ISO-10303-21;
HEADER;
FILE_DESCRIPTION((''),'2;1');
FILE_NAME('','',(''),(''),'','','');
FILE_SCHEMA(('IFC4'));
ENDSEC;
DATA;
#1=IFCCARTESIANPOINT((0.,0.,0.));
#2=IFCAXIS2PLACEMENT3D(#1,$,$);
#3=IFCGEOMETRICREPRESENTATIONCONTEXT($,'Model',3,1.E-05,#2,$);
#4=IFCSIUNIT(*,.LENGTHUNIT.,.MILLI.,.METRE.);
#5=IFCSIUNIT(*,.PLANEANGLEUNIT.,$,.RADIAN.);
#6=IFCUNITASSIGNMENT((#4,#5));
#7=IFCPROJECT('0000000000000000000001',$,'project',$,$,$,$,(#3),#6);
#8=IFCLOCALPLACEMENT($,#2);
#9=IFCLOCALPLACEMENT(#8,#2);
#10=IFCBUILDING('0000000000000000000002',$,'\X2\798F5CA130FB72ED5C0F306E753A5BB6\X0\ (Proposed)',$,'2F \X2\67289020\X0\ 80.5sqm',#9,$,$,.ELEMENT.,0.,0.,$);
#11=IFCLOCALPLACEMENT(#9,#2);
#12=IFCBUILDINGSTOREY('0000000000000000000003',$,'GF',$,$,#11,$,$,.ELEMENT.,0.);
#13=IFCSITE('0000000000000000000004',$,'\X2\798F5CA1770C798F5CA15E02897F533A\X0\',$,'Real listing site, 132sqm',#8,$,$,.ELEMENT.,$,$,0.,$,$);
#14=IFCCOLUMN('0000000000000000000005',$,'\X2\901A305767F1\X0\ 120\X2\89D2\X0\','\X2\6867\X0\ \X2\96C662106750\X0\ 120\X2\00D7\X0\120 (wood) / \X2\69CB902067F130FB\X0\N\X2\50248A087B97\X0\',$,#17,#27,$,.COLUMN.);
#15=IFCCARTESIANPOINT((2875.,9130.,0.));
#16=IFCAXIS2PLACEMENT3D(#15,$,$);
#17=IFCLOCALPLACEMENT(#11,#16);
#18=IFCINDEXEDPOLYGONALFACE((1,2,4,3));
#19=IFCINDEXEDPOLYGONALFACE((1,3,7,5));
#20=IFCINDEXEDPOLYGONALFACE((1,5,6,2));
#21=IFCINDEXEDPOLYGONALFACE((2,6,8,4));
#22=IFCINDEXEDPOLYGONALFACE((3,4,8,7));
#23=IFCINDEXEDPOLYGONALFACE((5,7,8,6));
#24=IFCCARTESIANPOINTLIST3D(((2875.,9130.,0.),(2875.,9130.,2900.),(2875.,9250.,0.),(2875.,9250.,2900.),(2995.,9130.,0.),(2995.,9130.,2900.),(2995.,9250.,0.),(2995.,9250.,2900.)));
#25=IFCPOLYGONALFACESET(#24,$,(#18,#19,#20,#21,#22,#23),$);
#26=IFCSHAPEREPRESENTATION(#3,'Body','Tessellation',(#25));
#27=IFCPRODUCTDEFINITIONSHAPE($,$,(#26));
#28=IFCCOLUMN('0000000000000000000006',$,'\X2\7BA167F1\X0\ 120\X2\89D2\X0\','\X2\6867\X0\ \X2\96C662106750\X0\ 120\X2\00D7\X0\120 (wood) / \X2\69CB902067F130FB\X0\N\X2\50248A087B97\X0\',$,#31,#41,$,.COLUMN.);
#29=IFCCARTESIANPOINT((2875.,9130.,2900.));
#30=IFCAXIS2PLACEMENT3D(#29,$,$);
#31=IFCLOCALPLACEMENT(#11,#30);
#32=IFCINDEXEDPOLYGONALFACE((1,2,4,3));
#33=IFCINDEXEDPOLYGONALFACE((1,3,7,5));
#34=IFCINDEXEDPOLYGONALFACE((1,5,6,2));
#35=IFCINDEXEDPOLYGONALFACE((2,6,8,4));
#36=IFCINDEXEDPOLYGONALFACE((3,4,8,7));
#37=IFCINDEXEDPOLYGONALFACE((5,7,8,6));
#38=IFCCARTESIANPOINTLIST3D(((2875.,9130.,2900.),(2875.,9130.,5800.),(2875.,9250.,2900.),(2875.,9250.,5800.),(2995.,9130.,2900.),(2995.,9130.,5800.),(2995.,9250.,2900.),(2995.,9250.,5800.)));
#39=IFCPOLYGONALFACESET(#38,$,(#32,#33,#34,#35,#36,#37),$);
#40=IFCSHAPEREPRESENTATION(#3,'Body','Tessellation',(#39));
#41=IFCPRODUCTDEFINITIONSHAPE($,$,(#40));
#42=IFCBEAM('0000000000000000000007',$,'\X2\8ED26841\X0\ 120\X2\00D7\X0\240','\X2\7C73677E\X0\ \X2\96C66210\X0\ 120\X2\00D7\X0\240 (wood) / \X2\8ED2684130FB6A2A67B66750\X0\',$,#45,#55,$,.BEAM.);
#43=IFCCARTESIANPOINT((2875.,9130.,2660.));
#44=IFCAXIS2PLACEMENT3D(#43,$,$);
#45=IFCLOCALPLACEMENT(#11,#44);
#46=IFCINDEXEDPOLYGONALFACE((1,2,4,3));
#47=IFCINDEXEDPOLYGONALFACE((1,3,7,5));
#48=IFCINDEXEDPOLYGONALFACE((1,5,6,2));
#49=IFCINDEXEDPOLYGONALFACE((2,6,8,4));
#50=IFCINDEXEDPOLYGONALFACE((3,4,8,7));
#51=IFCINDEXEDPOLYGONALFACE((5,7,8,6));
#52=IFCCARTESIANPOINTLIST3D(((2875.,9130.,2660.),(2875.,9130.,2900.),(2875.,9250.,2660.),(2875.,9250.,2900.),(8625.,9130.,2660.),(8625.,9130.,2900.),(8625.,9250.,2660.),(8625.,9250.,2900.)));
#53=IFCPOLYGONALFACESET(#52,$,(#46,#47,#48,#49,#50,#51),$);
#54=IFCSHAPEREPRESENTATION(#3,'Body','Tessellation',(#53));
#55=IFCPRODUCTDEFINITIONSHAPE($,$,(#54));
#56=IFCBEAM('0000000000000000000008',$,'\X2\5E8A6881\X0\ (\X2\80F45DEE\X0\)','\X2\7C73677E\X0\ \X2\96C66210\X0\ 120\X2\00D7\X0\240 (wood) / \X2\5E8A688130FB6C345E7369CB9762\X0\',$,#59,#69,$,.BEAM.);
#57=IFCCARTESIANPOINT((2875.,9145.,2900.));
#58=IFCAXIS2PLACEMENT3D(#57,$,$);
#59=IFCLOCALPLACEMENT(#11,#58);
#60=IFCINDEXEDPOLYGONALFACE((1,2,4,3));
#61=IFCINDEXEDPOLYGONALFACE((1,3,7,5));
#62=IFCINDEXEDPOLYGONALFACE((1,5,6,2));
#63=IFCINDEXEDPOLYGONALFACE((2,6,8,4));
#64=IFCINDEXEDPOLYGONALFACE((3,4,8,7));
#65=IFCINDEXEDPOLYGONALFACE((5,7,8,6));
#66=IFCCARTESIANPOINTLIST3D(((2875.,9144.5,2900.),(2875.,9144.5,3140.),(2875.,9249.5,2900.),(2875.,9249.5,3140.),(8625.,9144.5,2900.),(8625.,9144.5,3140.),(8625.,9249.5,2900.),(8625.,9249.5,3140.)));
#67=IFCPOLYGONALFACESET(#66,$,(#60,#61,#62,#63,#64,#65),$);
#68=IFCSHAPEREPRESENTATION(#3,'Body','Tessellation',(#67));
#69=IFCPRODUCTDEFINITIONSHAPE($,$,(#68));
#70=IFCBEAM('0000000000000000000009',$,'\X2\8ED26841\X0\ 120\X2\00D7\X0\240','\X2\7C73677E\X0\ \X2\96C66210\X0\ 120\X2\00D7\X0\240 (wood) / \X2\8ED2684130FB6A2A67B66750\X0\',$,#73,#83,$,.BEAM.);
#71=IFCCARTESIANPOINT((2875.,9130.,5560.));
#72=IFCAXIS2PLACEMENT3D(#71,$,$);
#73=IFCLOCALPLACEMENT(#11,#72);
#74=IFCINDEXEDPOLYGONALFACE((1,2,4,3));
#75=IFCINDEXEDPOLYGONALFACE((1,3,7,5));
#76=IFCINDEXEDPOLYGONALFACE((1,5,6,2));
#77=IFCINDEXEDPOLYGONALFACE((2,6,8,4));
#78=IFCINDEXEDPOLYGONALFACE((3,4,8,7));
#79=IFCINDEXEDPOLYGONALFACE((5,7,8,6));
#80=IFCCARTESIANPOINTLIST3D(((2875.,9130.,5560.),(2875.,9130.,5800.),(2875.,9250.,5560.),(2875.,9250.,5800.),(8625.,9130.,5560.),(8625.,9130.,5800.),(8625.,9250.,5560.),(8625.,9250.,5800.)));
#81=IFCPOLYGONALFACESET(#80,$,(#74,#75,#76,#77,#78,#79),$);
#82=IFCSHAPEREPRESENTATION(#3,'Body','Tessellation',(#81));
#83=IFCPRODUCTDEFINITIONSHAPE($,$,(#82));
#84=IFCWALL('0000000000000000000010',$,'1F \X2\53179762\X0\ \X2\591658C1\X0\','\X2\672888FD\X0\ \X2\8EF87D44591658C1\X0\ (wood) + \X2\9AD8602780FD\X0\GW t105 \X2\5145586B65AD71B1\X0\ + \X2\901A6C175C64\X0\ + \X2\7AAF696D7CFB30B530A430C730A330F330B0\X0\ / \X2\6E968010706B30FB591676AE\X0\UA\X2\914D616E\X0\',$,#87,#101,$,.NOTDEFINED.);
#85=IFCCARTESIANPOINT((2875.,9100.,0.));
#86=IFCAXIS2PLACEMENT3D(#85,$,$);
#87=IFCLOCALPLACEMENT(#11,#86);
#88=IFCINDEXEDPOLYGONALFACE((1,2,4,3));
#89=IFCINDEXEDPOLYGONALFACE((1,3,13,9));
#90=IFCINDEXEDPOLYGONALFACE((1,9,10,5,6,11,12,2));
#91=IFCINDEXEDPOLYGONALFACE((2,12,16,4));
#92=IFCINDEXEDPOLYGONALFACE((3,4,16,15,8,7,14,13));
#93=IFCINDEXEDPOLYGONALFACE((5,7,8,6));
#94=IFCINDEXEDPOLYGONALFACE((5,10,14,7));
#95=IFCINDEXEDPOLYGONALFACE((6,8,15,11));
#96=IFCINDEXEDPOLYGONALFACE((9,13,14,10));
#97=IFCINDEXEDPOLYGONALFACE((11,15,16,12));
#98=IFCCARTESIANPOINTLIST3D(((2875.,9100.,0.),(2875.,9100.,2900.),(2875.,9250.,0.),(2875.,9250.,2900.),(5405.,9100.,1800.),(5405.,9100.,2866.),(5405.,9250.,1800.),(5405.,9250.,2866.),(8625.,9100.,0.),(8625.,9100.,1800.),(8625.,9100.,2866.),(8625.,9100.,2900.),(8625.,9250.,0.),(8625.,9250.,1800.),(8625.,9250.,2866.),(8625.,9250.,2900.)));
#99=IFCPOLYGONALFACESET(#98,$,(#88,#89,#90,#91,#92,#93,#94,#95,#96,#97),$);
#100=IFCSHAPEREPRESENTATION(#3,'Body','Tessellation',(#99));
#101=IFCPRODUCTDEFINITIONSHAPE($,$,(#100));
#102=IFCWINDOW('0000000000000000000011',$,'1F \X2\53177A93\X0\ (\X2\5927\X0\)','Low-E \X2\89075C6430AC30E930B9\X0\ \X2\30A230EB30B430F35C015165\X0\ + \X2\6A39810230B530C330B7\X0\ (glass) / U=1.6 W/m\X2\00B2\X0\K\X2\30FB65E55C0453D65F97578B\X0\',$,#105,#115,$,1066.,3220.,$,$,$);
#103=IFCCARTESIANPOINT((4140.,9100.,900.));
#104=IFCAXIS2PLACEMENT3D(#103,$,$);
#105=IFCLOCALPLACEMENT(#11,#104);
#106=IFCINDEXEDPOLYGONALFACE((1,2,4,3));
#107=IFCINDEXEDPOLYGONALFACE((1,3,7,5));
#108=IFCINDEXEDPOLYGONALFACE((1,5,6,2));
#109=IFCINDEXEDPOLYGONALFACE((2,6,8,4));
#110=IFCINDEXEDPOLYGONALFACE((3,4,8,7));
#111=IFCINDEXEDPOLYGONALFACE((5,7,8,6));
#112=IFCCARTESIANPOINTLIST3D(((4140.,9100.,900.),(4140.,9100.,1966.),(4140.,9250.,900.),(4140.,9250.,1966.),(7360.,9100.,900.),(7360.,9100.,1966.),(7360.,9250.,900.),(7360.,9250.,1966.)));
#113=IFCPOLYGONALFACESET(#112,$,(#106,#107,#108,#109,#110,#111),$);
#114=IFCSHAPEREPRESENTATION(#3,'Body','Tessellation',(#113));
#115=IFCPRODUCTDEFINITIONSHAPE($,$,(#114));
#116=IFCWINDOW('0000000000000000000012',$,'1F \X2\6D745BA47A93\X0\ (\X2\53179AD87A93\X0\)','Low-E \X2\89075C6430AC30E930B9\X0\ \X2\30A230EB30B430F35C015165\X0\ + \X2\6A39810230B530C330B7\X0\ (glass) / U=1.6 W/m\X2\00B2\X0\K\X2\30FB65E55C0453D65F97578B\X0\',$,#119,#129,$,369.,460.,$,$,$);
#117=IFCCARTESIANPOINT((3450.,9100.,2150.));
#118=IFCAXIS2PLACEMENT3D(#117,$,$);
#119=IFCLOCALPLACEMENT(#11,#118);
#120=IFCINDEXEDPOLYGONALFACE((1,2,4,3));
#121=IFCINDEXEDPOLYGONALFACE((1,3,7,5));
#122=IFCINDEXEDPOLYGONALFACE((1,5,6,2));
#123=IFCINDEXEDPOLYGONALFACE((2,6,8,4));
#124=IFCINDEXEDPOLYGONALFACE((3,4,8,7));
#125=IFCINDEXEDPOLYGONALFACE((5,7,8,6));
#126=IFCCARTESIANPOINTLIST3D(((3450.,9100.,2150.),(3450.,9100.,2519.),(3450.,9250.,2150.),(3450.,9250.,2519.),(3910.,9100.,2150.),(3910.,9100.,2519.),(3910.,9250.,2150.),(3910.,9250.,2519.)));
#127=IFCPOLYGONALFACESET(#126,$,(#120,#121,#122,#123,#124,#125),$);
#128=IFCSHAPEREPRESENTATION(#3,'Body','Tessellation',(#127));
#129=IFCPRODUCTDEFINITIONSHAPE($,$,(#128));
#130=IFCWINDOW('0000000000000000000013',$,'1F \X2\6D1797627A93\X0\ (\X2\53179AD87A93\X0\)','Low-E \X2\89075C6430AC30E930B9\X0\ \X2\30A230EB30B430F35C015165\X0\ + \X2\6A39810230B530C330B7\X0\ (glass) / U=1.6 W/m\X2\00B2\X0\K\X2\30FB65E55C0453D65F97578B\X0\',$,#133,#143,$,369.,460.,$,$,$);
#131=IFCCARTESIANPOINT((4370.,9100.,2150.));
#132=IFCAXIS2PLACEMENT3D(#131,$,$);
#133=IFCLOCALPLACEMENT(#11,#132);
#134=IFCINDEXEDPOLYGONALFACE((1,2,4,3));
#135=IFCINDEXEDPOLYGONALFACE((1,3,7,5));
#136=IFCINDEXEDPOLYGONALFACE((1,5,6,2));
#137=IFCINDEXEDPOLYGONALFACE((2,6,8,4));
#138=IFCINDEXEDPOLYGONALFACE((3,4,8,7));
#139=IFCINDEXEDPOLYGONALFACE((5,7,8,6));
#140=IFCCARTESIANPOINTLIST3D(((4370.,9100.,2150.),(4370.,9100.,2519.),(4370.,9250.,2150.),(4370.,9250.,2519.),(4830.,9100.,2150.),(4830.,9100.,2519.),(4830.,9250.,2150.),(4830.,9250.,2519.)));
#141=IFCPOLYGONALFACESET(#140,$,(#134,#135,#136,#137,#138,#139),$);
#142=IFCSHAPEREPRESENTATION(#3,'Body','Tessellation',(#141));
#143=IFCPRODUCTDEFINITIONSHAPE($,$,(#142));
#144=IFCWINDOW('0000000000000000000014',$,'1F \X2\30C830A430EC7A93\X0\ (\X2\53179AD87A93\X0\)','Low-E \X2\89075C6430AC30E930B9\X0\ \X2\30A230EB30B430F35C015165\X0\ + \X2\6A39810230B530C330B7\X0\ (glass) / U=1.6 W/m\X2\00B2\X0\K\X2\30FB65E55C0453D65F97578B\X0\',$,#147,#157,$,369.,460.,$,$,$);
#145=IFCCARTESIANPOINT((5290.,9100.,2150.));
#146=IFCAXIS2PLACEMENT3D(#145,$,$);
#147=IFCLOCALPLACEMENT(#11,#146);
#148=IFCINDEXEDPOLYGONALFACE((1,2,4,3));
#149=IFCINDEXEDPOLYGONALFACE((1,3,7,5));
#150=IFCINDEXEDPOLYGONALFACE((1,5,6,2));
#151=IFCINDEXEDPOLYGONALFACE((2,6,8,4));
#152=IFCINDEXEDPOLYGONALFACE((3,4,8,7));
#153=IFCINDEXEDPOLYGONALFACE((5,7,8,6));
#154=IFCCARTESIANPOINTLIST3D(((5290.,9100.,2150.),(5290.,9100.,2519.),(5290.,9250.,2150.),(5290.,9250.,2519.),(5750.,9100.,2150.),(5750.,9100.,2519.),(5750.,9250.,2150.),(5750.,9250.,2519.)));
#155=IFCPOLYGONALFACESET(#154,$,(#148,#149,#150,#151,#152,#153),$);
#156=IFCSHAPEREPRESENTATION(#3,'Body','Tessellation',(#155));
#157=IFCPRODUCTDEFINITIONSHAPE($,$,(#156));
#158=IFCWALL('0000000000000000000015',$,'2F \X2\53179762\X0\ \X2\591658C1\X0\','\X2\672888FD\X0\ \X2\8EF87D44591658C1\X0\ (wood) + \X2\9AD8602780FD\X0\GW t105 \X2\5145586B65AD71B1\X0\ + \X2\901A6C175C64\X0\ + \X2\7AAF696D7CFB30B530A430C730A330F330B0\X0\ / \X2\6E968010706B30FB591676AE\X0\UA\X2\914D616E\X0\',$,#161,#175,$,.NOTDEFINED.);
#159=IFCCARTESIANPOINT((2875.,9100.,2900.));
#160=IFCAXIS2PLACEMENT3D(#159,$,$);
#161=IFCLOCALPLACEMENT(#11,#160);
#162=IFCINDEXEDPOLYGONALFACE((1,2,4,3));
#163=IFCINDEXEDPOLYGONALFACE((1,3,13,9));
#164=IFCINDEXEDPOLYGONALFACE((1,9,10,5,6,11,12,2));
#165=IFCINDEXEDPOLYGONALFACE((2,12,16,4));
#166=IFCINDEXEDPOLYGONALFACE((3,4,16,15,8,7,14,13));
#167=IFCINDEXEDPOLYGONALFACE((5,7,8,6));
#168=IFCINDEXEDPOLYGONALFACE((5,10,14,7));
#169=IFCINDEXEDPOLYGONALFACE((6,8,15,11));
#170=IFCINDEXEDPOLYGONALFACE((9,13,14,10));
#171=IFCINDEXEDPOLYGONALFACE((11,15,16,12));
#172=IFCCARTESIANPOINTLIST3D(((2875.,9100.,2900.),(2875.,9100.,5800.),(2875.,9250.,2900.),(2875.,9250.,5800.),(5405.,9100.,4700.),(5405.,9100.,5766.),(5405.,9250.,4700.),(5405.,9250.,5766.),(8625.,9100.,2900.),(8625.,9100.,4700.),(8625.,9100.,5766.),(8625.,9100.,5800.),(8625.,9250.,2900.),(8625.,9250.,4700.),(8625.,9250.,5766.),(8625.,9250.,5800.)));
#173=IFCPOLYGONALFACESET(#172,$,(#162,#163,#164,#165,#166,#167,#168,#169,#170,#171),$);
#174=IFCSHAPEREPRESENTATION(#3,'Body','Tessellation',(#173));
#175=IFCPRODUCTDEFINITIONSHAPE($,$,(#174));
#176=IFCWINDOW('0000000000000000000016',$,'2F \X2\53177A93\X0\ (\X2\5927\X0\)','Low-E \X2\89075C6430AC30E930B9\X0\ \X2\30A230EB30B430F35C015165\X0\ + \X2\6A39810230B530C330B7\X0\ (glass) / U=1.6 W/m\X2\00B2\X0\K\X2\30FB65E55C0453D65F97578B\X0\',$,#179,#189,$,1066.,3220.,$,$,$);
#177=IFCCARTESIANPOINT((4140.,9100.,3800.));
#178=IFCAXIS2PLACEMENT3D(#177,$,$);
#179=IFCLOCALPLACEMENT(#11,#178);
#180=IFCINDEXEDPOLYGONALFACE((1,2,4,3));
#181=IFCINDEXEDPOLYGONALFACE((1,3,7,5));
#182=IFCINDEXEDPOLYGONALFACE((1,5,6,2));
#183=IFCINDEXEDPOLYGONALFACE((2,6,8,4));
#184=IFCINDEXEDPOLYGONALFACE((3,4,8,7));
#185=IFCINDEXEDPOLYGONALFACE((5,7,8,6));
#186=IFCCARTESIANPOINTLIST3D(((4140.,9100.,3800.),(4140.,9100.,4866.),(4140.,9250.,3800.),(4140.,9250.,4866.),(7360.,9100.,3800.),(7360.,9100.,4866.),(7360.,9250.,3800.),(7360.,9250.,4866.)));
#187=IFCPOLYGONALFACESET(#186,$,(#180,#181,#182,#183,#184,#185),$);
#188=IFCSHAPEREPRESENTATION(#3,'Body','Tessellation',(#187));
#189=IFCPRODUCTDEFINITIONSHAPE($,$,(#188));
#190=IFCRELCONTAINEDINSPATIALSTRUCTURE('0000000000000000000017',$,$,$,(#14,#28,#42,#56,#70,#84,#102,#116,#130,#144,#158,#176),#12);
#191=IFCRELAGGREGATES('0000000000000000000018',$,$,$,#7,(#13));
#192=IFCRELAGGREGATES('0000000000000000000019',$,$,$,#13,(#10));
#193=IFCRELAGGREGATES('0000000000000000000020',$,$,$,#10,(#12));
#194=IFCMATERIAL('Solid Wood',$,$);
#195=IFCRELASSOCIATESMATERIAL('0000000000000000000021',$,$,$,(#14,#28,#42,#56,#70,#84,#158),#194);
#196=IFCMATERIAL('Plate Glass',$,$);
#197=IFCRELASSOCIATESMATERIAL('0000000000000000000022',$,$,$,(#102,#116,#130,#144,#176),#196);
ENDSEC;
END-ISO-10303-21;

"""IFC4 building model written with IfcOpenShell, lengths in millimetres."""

from ifc_helpers import new_model, si_unit, frame, frame_2d, origin, place, context, project, spatial, rectangle, extrude, material, element, fill, save


model = new_model("IFC4")

# Units and contexts
model_context = context("Model", 3, precision=1e-05, world=origin())
ifc_project = project(units=[si_unit("LENGTHUNIT", "METRE", prefix="MILLI"), si_unit("PLANEANGLEUNIT", "RADIAN")], contexts=[model_context])

# Site, building, storey
site_placement = place(None, origin())
site = spatial("IfcSite", under=ifc_project, at=site_placement, Name="福岡県福岡市西区", ObjectType="Real listing site, 132sqm", CompositionType="ELEMENT", RefElevation=0.0)
building_placement = place(site_placement, origin())
building = spatial("IfcBuilding", under=site, at=building_placement, Name="福岡・狭小の町家 (Proposed)", ObjectType="2F 木造 80.5sqm", CompositionType="ELEMENT", ElevationOfRefHeight=0.0, ElevationOfTerrain=0.0)
storey_placement = place(building_placement, origin())
storey = spatial("IfcBuildingStorey", under=building, at=storey_placement, Name="GF", CompositionType="ELEMENT", Elevation=0.0)

# Columns
ifc_material_1 = material(Name="Solid Wood")
column_1_placement = place(storey_placement, frame((2875.0, 9130.0, 0.0)))
element("IfcColumn", 1, at=column_1_placement, inside=storey, material=ifc_material_1, Name="通し柱 120角", Description="桧 集成材 120×120 (wood) / 構造柱・N値計算", PredefinedType="COLUMN", context=model_context, shape_type="SweptSolid", body=[
    extrude(rectangle(XDim=120.0, YDim=120.0, at=frame_2d((60.0, 60.0))), frame((2875.0, 9130.0, 0.0)), (0.0, 0.0, 1.0), 2900.0),
])
column_2_placement = place(storey_placement, frame((2875.0, 9130.0, 2900.0)))
element("IfcColumn", 2, at=column_2_placement, inside=storey, material=ifc_material_1, Name="管柱 120角", Description="桧 集成材 120×120 (wood) / 構造柱・N値計算", PredefinedType="COLUMN", context=model_context, shape_type="SweptSolid", body=[
    extrude(rectangle(XDim=120.0, YDim=120.0, at=frame_2d((60.0, 60.0))), frame((2875.0, 9130.0, 2900.0)), (0.0, 0.0, 1.0), 2900.0),
])

# Beams
beam_1_placement = place(storey_placement, frame((2875.0, 9130.0, 2660.0)))
element("IfcBeam", 3, at=beam_1_placement, inside=storey, material=ifc_material_1, Name="軒桁 120×240", Description="米松 集成 120×240 (wood) / 軒桁・横架材", PredefinedType="BEAM", context=model_context, shape_type="SweptSolid", body=[
    extrude(rectangle(XDim=5750.0, YDim=120.0, at=frame_2d((2875.0, 60.0))), frame((2875.0, 9130.0, 2660.0)), (0.0, 0.0, 1.0), 240.0),
])
beam_2_placement = place(storey_placement, frame((2875.0, 9145.0, 2900.0)))
element("IfcBeam", 4, at=beam_2_placement, inside=storey, material=ifc_material_1, Name="床梁 (胴差)", Description="米松 集成 120×240 (wood) / 床梁・水平構面", PredefinedType="BEAM", context=model_context, shape_type="SweptSolid", body=[
    extrude(rectangle(XDim=5750.0, YDim=105.0, at=frame_2d((2875.0, 52.0))), frame((2875.0, 9145.0, 2900.0)), (0.0, 0.0, 1.0), 240.0),
])
beam_3_placement = place(storey_placement, frame((2875.0, 9130.0, 5560.0)))
element("IfcBeam", 5, at=beam_3_placement, inside=storey, material=ifc_material_1, Name="軒桁 120×240", Description="米松 集成 120×240 (wood) / 軒桁・横架材", PredefinedType="BEAM", context=model_context, shape_type="SweptSolid", body=[
    extrude(rectangle(XDim=5750.0, YDim=120.0, at=frame_2d((2875.0, 60.0))), frame((2875.0, 9130.0, 5560.0)), (0.0, 0.0, 1.0), 240.0),
])

# Wall, openings, windows
wall_1_placement = place(storey_placement, frame((2875.0, 9100.0, 0.0)))
wall_1 = element("IfcWall", 6, at=wall_1_placement, inside=storey, material=ifc_material_1, Name="1F 北面 外壁", Description="木製 軸組外壁 (wood) + 高性能GW t105 充填断熱 + 通気層 + 窯業系サイディング / 準耐火・外皮UA配慮", PredefinedType="NOTDEFINED", context=model_context, shape_type="SweptSolid", body=[
    extrude(rectangle(XDim=5750.0, YDim=150.0, at=frame_2d((2875.0, 75.0))), frame((2875.0, 9100.0, 0.0)), (0.0, 0.0, 1.0), 2900.0),
])
opening_1_placement = place(storey_placement, frame((4140.0, 9100.0, 900.0)))
opening_1 = element("IfcOpeningElement", 7, at=opening_1_placement, cuts=wall_1, PredefinedType="NOTDEFINED", context=model_context, shape_type="SweptSolid", body=[
    extrude(rectangle(XDim=3220.0, YDim=150.0, at=frame_2d((1610.0, 75.0))), frame((4140.0, 9100.0, 900.0)), (0.0, 0.0, 1.0), 1066.0),
])
opening_2_placement = place(storey_placement, frame((3450.0, 9100.0, 2150.0)))
opening_2 = element("IfcOpeningElement", 8, at=opening_2_placement, cuts=wall_1, PredefinedType="NOTDEFINED", context=model_context, shape_type="SweptSolid", body=[
    extrude(rectangle(XDim=460.0, YDim=150.0, at=frame_2d((230.0, 75.0))), frame((3450.0, 9100.0, 2150.0)), (0.0, 0.0, 1.0), 369.0),
])
opening_3_placement = place(storey_placement, frame((4370.0, 9100.0, 2150.0)))
opening_3 = element("IfcOpeningElement", 9, at=opening_3_placement, cuts=wall_1, PredefinedType="NOTDEFINED", context=model_context, shape_type="SweptSolid", body=[
    extrude(rectangle(XDim=460.0, YDim=150.0, at=frame_2d((230.0, 75.0))), frame((4370.0, 9100.0, 2150.0)), (0.0, 0.0, 1.0), 369.0),
])
opening_4_placement = place(storey_placement, frame((5290.0, 9100.0, 2150.0)))
opening_4 = element("IfcOpeningElement", 10, at=opening_4_placement, cuts=wall_1, PredefinedType="NOTDEFINED", context=model_context, shape_type="SweptSolid", body=[
    extrude(rectangle(XDim=460.0, YDim=150.0, at=frame_2d((230.0, 75.0))), frame((5290.0, 9100.0, 2150.0)), (0.0, 0.0, 1.0), 369.0),
])
ifc_material_2 = material(Name="Plate Glass")
window_1_placement = place(storey_placement, frame((4140.0, 9100.0, 900.0)))
window_1 = element("IfcWindow", 11, at=window_1_placement, inside=storey, material=ifc_material_2, Name="1F 北窓 (大)", Description="Low-E 複層ガラス アルゴン封入 + 樹脂サッシ (glass) / U=1.6 W/m²K・日射取得型", OverallHeight=1066.0, OverallWidth=3220.0, context=model_context, shape_type="SweptSolid", body=[
    extrude(rectangle(XDim=3220.0, YDim=150.0, at=frame_2d((1610.0, 75.0))), frame((4140.0, 9100.0, 900.0)), (0.0, 0.0, 1.0), 1066.0),
])
fill(opening_1, window_1)
window_2_placement = place(storey_placement, frame((3450.0, 9100.0, 2150.0)))
window_2 = element("IfcWindow", 12, at=window_2_placement, inside=storey, material=ifc_material_2, Name="1F 浴室窓 (北高窓)", Description="Low-E 複層ガラス アルゴン封入 + 樹脂サッシ (glass) / U=1.6 W/m²K・日射取得型", OverallHeight=369.0, OverallWidth=460.0, context=model_context, shape_type="SweptSolid", body=[
    extrude(rectangle(XDim=460.0, YDim=150.0, at=frame_2d((230.0, 75.0))), frame((3450.0, 9100.0, 2150.0)), (0.0, 0.0, 1.0), 369.0),
])
fill(opening_2, window_2)
window_3_placement = place(storey_placement, frame((4370.0, 9100.0, 2150.0)))
window_3 = element("IfcWindow", 13, at=window_3_placement, inside=storey, material=ifc_material_2, Name="1F 洗面窓 (北高窓)", Description="Low-E 複層ガラス アルゴン封入 + 樹脂サッシ (glass) / U=1.6 W/m²K・日射取得型", OverallHeight=369.0, OverallWidth=460.0, context=model_context, shape_type="SweptSolid", body=[
    extrude(rectangle(XDim=460.0, YDim=150.0, at=frame_2d((230.0, 75.0))), frame((4370.0, 9100.0, 2150.0)), (0.0, 0.0, 1.0), 369.0),
])
fill(opening_3, window_3)
window_4_placement = place(storey_placement, frame((5290.0, 9100.0, 2150.0)))
window_4 = element("IfcWindow", 14, at=window_4_placement, inside=storey, material=ifc_material_2, Name="1F トイレ窓 (北高窓)", Description="Low-E 複層ガラス アルゴン封入 + 樹脂サッシ (glass) / U=1.6 W/m²K・日射取得型", OverallHeight=369.0, OverallWidth=460.0, context=model_context, shape_type="SweptSolid", body=[
    extrude(rectangle(XDim=460.0, YDim=150.0, at=frame_2d((230.0, 75.0))), frame((5290.0, 9100.0, 2150.0)), (0.0, 0.0, 1.0), 369.0),
])
fill(opening_4, window_4)

# Wall, opening, window
wall_2_placement = place(storey_placement, frame((2875.0, 9100.0, 2900.0)))
wall_2 = element("IfcWall", 15, at=wall_2_placement, inside=storey, material=ifc_material_1, Name="2F 北面 外壁", Description="木製 軸組外壁 (wood) + 高性能GW t105 充填断熱 + 通気層 + 窯業系サイディング / 準耐火・外皮UA配慮", PredefinedType="NOTDEFINED", context=model_context, shape_type="SweptSolid", body=[
    extrude(rectangle(XDim=5750.0, YDim=150.0, at=frame_2d((2875.0, 75.0))), frame((2875.0, 9100.0, 2900.0)), (0.0, 0.0, 1.0), 2900.0),
])
opening_5_placement = place(storey_placement, frame((4140.0, 9100.0, 3800.0)))
opening_5 = element("IfcOpeningElement", 16, at=opening_5_placement, cuts=wall_2, PredefinedType="NOTDEFINED", context=model_context, shape_type="SweptSolid", body=[
    extrude(rectangle(XDim=3220.0, YDim=150.0, at=frame_2d((1610.0, 75.0))), frame((4140.0, 9100.0, 3800.0)), (0.0, 0.0, 1.0), 1066.0),
])
window_5_placement = place(storey_placement, frame((4140.0, 9100.0, 3800.0)))
window_5 = element("IfcWindow", 17, at=window_5_placement, inside=storey, material=ifc_material_2, Name="2F 北窓 (大)", Description="Low-E 複層ガラス アルゴン封入 + 樹脂サッシ (glass) / U=1.6 W/m²K・日射取得型", OverallHeight=1066.0, OverallWidth=3220.0, context=model_context, shape_type="SweptSolid", body=[
    extrude(rectangle(XDim=3220.0, YDim=150.0, at=frame_2d((1610.0, 75.0))), frame((4140.0, 9100.0, 3800.0)), (0.0, 0.0, 1.0), 1066.0),
])
fill(opening_5, window_5)

save(model, "model.ifc")
